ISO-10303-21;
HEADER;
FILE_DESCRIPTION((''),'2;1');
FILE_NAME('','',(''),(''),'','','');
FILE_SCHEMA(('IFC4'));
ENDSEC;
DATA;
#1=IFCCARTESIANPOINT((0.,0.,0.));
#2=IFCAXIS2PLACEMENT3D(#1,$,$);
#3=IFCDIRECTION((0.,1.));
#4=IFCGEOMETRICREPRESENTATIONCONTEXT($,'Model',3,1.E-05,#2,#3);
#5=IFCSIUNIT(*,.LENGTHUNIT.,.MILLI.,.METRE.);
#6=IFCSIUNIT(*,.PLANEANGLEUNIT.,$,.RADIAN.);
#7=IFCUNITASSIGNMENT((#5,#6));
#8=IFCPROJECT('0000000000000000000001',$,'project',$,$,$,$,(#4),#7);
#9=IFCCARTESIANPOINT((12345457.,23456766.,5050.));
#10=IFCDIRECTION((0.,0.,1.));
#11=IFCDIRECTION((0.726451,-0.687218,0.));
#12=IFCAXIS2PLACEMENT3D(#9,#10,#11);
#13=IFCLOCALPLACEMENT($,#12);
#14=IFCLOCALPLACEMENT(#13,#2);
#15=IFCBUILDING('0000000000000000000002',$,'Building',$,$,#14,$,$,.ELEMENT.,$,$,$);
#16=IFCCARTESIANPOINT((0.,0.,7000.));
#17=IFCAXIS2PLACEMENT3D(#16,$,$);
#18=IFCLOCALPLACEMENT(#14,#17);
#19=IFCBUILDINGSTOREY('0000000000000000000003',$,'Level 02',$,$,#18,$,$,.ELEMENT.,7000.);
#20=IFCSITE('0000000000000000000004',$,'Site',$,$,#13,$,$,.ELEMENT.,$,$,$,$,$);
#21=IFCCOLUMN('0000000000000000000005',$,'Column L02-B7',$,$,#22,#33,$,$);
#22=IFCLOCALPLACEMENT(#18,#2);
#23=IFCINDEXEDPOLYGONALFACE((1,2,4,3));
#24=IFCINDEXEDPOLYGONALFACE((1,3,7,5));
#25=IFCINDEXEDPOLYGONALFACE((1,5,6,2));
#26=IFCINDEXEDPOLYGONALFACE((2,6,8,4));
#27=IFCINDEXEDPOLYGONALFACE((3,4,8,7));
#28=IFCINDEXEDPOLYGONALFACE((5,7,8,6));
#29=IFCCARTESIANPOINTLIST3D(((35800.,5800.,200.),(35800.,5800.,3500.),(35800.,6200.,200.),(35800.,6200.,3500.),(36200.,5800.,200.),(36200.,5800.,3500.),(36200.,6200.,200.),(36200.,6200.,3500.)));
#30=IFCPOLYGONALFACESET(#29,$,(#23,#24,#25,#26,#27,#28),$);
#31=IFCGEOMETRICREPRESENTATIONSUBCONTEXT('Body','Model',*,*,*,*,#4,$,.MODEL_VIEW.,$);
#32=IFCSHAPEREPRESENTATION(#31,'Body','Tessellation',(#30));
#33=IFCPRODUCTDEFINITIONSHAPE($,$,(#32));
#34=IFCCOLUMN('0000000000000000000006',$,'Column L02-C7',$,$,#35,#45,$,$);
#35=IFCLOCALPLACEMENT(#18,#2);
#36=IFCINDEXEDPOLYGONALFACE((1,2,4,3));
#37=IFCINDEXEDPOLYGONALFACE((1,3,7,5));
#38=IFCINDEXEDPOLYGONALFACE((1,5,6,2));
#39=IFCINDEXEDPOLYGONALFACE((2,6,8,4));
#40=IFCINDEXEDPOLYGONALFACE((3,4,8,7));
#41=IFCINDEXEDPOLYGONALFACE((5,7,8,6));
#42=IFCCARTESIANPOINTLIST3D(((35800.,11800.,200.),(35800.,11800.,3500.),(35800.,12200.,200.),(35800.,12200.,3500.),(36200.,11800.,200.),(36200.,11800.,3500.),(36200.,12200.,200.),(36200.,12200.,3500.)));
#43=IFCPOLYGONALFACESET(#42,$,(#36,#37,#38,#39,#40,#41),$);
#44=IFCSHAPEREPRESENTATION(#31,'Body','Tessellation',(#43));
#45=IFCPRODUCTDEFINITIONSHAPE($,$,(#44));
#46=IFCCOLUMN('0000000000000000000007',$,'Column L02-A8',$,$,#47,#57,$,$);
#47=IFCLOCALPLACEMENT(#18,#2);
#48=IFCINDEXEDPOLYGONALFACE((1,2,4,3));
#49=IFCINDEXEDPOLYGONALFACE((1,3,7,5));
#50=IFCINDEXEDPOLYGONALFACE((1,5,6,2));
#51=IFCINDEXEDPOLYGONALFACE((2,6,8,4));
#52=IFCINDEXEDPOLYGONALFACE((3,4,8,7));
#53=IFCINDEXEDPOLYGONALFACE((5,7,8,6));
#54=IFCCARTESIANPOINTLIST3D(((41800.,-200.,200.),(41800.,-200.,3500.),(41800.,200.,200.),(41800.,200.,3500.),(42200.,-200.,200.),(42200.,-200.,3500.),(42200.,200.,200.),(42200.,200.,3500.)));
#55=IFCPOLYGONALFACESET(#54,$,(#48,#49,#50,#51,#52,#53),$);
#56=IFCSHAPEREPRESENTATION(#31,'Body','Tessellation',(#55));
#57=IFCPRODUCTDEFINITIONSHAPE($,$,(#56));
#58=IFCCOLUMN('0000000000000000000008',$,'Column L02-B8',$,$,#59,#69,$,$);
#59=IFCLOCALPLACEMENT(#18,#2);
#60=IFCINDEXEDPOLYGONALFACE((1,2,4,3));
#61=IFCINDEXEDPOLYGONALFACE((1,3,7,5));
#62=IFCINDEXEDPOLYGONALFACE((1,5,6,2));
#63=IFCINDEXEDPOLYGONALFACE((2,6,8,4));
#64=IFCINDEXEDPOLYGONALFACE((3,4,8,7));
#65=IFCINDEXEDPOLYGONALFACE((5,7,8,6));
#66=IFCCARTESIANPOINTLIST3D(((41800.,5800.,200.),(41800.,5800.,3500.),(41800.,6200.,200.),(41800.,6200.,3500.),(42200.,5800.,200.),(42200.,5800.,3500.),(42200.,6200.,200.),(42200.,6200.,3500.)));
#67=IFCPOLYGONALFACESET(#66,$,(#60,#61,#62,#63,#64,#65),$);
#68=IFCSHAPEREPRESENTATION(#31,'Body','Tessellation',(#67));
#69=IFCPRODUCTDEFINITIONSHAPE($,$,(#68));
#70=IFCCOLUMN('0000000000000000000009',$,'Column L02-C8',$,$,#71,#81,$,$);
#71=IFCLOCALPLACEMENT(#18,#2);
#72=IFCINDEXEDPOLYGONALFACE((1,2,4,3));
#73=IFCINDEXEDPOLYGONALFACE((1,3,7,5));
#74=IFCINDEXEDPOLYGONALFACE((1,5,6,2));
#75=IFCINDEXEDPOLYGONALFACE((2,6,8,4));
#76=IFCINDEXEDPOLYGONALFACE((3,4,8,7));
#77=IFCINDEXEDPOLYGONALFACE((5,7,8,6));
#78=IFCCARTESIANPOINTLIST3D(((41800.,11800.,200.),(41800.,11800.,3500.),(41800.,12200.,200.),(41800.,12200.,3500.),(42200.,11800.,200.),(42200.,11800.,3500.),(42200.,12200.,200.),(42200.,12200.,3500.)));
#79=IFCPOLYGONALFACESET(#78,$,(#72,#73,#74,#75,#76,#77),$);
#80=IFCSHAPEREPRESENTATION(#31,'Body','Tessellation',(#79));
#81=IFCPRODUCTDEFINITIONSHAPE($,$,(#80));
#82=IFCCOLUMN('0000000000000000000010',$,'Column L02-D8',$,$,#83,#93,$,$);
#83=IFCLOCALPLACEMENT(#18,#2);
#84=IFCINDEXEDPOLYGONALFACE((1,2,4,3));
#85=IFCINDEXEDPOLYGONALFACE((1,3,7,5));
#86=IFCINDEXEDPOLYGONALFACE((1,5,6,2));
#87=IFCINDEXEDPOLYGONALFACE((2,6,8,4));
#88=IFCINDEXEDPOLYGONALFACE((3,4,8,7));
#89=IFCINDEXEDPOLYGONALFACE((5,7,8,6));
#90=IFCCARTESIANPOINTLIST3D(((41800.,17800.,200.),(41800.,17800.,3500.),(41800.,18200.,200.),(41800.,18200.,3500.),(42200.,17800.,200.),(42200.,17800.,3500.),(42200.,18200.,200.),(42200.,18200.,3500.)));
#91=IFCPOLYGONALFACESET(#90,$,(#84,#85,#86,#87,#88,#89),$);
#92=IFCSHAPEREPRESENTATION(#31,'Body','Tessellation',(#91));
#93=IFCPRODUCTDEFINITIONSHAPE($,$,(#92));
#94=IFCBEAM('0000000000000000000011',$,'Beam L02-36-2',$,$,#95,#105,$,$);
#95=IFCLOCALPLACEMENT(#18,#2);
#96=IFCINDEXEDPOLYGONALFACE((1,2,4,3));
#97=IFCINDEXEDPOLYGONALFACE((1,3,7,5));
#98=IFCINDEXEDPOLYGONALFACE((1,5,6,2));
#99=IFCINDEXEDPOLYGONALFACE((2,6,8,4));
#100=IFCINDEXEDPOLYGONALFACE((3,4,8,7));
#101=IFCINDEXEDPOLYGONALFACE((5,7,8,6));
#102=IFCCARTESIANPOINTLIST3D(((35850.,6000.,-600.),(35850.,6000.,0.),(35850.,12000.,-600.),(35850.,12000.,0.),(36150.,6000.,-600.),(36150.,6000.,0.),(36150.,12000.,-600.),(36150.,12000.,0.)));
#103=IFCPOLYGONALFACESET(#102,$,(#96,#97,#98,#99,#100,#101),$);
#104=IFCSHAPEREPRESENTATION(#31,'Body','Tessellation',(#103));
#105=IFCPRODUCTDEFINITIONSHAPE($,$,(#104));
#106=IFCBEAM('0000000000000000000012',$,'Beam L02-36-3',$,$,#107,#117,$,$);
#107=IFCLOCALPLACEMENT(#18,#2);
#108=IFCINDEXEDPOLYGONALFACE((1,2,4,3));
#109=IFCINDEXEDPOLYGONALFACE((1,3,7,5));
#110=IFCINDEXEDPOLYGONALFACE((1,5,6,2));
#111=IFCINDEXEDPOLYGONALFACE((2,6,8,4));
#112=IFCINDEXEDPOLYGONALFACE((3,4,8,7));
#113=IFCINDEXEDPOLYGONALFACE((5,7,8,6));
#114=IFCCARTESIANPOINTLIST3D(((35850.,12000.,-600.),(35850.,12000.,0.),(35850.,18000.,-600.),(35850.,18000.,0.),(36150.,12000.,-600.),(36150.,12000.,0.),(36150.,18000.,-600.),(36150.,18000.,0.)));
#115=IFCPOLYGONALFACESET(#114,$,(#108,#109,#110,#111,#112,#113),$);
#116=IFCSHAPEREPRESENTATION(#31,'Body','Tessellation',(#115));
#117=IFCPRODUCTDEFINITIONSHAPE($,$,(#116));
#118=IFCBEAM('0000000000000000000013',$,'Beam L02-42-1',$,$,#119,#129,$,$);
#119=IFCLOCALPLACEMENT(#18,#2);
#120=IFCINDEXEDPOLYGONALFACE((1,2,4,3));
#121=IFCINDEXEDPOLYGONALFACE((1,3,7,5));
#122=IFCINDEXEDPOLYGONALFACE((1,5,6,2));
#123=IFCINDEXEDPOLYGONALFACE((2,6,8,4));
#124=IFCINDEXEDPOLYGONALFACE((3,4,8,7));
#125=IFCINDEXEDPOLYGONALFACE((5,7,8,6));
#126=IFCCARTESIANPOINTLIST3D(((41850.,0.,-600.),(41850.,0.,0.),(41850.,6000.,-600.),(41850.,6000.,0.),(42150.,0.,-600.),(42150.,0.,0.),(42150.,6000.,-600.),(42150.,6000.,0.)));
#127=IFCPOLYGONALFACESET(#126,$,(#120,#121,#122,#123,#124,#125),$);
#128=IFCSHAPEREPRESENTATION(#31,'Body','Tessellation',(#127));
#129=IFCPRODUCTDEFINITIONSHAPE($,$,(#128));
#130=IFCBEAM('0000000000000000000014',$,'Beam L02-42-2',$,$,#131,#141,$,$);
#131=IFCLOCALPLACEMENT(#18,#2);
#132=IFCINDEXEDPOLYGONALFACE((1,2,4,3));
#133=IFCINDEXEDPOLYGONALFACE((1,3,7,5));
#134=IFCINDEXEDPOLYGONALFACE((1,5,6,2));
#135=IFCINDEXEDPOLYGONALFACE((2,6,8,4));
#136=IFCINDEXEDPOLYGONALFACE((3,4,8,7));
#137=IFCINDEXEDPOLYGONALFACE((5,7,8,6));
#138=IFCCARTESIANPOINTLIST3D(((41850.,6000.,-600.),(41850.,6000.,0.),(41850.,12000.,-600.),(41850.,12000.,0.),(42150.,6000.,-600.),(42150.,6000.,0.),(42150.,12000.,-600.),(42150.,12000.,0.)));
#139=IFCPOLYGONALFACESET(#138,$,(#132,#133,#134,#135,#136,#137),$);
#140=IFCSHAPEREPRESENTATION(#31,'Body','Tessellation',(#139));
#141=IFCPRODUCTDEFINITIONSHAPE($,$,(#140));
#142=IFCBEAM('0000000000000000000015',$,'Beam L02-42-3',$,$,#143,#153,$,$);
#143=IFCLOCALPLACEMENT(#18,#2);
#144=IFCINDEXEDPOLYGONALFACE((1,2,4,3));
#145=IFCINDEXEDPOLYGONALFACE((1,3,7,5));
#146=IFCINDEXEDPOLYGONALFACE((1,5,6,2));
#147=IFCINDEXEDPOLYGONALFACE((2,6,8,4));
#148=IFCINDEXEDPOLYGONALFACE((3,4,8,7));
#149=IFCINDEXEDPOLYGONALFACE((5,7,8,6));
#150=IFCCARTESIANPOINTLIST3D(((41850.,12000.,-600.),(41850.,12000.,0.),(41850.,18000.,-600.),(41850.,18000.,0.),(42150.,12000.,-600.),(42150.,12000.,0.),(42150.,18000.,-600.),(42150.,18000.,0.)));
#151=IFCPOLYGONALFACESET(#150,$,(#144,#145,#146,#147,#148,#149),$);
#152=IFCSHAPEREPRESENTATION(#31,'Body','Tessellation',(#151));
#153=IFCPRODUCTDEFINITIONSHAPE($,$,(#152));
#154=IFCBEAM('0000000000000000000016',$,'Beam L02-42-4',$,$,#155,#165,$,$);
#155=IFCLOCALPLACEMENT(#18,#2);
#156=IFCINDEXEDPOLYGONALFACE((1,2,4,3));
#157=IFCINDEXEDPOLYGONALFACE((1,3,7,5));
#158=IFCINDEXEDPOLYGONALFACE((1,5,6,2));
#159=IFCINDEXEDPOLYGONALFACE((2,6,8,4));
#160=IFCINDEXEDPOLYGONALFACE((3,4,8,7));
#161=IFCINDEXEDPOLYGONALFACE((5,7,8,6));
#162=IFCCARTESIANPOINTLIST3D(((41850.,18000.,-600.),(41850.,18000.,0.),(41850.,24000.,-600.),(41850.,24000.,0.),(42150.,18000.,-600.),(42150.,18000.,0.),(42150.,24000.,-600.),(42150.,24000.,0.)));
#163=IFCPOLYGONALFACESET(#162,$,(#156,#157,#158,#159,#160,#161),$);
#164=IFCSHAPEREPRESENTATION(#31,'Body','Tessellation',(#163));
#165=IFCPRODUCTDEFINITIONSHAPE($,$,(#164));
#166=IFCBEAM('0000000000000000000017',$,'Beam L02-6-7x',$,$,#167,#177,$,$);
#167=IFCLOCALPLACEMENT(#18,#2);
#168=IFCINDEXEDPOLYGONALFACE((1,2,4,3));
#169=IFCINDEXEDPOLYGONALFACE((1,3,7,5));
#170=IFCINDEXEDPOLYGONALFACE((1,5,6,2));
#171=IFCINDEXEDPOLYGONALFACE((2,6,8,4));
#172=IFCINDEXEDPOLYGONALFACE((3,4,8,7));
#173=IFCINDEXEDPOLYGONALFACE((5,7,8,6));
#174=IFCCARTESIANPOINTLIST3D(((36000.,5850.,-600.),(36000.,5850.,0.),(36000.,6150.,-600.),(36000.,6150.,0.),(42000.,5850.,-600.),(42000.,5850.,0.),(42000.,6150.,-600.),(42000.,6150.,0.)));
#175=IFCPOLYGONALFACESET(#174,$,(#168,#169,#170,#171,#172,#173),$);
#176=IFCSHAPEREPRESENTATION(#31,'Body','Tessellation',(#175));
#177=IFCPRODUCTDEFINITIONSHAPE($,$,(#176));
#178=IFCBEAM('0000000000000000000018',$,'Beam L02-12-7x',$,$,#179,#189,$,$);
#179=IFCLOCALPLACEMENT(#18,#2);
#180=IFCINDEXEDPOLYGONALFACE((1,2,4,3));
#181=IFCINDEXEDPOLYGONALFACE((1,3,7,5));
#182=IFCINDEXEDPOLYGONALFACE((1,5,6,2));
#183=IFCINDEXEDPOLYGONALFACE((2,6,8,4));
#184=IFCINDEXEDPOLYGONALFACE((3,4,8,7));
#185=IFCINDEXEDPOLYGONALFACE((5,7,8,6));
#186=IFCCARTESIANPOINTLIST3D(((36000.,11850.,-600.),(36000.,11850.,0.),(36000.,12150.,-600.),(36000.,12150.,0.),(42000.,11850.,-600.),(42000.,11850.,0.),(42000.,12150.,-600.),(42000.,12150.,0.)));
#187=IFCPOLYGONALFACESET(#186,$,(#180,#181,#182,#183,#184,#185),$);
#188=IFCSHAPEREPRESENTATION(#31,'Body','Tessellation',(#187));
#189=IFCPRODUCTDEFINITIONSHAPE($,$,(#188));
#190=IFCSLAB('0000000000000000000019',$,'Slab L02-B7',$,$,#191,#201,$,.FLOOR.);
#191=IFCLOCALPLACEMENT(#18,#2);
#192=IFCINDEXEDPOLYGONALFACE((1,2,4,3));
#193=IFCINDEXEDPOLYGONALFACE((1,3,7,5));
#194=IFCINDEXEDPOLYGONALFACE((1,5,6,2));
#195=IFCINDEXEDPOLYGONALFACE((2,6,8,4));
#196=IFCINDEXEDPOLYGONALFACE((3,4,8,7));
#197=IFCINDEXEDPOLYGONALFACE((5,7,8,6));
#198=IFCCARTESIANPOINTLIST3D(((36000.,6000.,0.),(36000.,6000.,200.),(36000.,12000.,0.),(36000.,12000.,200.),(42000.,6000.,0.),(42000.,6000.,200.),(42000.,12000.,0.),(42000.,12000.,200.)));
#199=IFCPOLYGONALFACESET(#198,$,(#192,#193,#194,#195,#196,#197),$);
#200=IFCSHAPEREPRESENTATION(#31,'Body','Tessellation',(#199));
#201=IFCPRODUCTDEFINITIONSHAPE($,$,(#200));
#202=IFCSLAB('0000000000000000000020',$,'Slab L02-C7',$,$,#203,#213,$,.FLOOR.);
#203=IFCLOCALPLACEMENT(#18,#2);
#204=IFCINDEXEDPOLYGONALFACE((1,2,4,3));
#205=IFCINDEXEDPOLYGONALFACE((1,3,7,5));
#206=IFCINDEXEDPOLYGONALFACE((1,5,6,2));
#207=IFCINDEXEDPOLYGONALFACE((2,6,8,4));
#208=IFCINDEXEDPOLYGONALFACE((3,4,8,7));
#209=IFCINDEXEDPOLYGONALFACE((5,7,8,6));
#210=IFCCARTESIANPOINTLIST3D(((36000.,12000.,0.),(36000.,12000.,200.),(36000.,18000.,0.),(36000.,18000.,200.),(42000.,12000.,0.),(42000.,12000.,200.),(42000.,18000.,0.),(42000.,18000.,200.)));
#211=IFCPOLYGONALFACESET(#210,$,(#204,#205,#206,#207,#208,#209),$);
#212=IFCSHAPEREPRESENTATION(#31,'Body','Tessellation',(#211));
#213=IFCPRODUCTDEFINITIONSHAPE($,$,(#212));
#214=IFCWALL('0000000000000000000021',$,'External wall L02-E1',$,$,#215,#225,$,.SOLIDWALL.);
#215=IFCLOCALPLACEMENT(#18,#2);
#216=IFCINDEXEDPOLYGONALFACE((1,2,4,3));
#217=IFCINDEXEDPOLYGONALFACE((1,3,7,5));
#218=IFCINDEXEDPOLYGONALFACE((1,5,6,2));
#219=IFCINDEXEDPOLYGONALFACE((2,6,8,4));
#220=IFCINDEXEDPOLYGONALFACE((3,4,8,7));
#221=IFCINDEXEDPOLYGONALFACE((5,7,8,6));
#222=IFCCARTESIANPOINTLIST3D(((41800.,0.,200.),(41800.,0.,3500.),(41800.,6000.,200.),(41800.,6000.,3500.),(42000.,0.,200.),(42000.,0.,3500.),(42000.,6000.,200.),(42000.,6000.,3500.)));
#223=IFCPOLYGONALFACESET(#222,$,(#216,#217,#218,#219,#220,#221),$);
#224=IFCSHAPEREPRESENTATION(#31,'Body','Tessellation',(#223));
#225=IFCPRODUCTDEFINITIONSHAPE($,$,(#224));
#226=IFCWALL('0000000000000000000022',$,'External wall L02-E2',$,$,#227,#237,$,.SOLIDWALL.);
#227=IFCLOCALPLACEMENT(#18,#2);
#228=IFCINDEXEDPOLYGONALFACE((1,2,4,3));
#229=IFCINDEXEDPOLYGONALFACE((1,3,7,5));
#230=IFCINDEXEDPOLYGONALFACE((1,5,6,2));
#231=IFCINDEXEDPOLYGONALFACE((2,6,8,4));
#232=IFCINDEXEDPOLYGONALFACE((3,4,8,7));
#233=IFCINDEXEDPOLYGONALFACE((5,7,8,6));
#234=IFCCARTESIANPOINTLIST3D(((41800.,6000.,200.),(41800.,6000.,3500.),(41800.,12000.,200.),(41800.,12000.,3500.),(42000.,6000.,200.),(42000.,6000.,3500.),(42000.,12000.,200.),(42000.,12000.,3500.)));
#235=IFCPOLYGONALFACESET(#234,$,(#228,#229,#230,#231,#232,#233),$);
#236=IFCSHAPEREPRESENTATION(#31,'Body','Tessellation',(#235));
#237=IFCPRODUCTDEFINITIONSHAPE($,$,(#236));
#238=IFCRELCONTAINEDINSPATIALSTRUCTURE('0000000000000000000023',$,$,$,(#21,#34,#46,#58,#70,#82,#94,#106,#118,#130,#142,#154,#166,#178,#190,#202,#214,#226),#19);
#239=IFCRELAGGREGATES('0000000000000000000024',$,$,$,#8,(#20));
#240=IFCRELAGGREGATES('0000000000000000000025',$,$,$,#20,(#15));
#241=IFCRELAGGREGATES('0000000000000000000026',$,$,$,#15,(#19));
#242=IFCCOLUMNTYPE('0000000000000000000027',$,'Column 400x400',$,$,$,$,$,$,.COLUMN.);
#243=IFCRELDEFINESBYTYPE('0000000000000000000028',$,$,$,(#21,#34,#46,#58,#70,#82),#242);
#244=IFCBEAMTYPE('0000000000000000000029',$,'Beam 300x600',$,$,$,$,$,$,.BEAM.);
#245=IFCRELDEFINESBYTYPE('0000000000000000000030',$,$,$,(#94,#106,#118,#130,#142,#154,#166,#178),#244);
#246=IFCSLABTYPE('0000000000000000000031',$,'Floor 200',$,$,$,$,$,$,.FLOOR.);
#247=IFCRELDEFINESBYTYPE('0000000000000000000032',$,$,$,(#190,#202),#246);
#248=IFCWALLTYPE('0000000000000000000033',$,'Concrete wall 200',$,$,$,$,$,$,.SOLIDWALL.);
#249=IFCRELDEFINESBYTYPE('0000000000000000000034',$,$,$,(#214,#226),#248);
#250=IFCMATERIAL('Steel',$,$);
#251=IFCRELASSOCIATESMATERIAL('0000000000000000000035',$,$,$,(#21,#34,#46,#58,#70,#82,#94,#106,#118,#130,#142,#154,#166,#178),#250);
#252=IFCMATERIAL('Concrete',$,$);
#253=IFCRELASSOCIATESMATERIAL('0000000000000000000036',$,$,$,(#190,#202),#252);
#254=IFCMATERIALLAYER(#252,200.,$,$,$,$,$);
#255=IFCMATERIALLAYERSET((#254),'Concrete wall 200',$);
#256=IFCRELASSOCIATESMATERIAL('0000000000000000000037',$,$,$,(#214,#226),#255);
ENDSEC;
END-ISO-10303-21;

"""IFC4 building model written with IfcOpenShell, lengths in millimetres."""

from ifc_helpers import new_model, si_unit, direction, frame, origin, place, context, subcontext, project, spatial, rectangle, extrude, material, layer, layer_set, layer_usage, type_object, element, save


model = new_model("IFC4")

# Units and contexts
model_context = context("Model", 3, precision=1e-05, world=origin(), true_north=direction((0.0, 1.0)))
body_context = subcontext(model_context, "Body", "Model", "MODEL_VIEW")
ifc_project = project(units=[si_unit("LENGTHUNIT", "METRE", prefix="MILLI"), si_unit("PLANEANGLEUNIT", "RADIAN")], contexts=[model_context])

# Site, building, storey
site_placement = place(None, frame((12345457.0, 23456766.0, 5050.0), z_axis=(0.0, 0.0, 1.0), x_axis=(0.726451, -0.687218, 0.0)))
site = spatial("IfcSite", under=ifc_project, at=site_placement, Name="Site", CompositionType="ELEMENT")
building_placement = place(site_placement, origin())
building = spatial("IfcBuilding", under=site, at=building_placement, Name="Building", CompositionType="ELEMENT")
storey_placement = place(building_placement, frame((0.0, 0.0, 7000.0)))
storey = spatial("IfcBuildingStorey", under=building, at=storey_placement, Name="Level 02", CompositionType="ELEMENT", Elevation=7000.0)

# Columns
ifc_material_1 = material(Name="Steel")
column_type = type_object("IfcColumnType", Name="Column 400x400", PredefinedType="COLUMN")
for number, where, name in (
    (1, (35800.0, 5800.0, 200.0), "Column L02-B7"),
    (2, (35800.0, 11800.0, 200.0), "Column L02-C7"),
    (3, (41800.0, -200.0, 200.0), "Column L02-A8"),
    (4, (41800.0, 5800.0, 200.0), "Column L02-B8"),
    (5, (41800.0, 11800.0, 200.0), "Column L02-C8"),
    (6, (41800.0, 17800.0, 200.0), "Column L02-D8"),
):
    element("IfcColumn", number, at=place(storey_placement, frame(where)), inside=storey, type_object=column_type, material=ifc_material_1, Name=name, context=body_context, shape_type="SweptSolid", body=[
        extrude(rectangle(XDim=400.0, YDim=400.0), frame((200.0, 200.0, 0.0)), (0.0, 0.0, 1.0), 3300.0),
    ])

# Beams
beam_type = type_object("IfcBeamType", Name="Beam 300x600", PredefinedType="BEAM")
for number, where, name in (
    (7, (35850.0, 6000.0, -600.0), "Beam L02-36-2"),
    (8, (35850.0, 12000.0, -600.0), "Beam L02-36-3"),
    (9, (41850.0, 0.0, -600.0), "Beam L02-42-1"),
    (10, (41850.0, 6000.0, -600.0), "Beam L02-42-2"),
    (11, (41850.0, 12000.0, -600.0), "Beam L02-42-3"),
    (12, (41850.0, 18000.0, -600.0), "Beam L02-42-4"),
):
    element("IfcBeam", number, at=place(storey_placement, frame(where)), inside=storey, type_object=beam_type, material=ifc_material_1, Name=name, context=body_context, shape_type="SweptSolid", body=[
        extrude(rectangle(XDim=300.0, YDim=6000.0), frame((150.0, 3000.0, 0.0)), (0.0, 0.0, 1.0), 600.0),
    ])
for number, where, name in (
    (13, (36000.0, 5850.0, -600.0), "Beam L02-6-7x"),
    (14, (36000.0, 11850.0, -600.0), "Beam L02-12-7x"),
):
    element("IfcBeam", number, at=place(storey_placement, frame(where)), inside=storey, type_object=beam_type, material=ifc_material_1, Name=name, context=body_context, shape_type="SweptSolid", body=[
        extrude(rectangle(XDim=6000.0, YDim=300.0), frame((3000.0, 150.0, 0.0)), (0.0, 0.0, 1.0), 600.0),
    ])

# Slabs
ifc_material_2 = material(Name="Concrete")
slab_type = type_object("IfcSlabType", Name="Floor 200", PredefinedType="FLOOR")
for number, where, name in (
    (15, (36000.0, 6000.0, 0.0), "Slab L02-B7"),
    (16, (36000.0, 12000.0, 0.0), "Slab L02-C7"),
):
    element("IfcSlab", number, at=place(storey_placement, frame(where)), inside=storey, type_object=slab_type, material=ifc_material_2, Name=name, PredefinedType="FLOOR", context=body_context, shape_type="SweptSolid", body=[
        extrude(rectangle(XDim=6000.0, YDim=6000.0), frame((3000.0, 3000.0, 0.0)), (0.0, 0.0, 1.0), 200.0),
    ])

# Walls
ifc_layer_1 = layer(ifc_material_2, 200.0)
ifc_layer_set_1 = layer_set([ifc_layer_1], Name="Concrete wall 200")
ifc_layer_usage_1 = layer_usage(ifc_layer_set_1, "AXIS2", "POSITIVE", 0.0)
wall_type_1 = type_object("IfcWallType", Name="Concrete wall 200", PredefinedType="SOLIDWALL")
for number, where, name in (
    (17, (41800.0, 0.0, 200.0), "External wall L02-E1"),
    (18, (41800.0, 6000.0, 200.0), "External wall L02-E2"),
):
    element("IfcWall", number, at=place(storey_placement, frame(where)), inside=storey, type_object=wall_type_1, material=ifc_layer_usage_1, Name=name, PredefinedType="SOLIDWALL", context=body_context, shape_type="SweptSolid", body=[
        extrude(rectangle(XDim=200.0, YDim=6000.0), frame((100.0, 3000.0, 0.0)), (0.0, 0.0, 1.0), 3300.0),
    ])

save(model, "model.ifc")
